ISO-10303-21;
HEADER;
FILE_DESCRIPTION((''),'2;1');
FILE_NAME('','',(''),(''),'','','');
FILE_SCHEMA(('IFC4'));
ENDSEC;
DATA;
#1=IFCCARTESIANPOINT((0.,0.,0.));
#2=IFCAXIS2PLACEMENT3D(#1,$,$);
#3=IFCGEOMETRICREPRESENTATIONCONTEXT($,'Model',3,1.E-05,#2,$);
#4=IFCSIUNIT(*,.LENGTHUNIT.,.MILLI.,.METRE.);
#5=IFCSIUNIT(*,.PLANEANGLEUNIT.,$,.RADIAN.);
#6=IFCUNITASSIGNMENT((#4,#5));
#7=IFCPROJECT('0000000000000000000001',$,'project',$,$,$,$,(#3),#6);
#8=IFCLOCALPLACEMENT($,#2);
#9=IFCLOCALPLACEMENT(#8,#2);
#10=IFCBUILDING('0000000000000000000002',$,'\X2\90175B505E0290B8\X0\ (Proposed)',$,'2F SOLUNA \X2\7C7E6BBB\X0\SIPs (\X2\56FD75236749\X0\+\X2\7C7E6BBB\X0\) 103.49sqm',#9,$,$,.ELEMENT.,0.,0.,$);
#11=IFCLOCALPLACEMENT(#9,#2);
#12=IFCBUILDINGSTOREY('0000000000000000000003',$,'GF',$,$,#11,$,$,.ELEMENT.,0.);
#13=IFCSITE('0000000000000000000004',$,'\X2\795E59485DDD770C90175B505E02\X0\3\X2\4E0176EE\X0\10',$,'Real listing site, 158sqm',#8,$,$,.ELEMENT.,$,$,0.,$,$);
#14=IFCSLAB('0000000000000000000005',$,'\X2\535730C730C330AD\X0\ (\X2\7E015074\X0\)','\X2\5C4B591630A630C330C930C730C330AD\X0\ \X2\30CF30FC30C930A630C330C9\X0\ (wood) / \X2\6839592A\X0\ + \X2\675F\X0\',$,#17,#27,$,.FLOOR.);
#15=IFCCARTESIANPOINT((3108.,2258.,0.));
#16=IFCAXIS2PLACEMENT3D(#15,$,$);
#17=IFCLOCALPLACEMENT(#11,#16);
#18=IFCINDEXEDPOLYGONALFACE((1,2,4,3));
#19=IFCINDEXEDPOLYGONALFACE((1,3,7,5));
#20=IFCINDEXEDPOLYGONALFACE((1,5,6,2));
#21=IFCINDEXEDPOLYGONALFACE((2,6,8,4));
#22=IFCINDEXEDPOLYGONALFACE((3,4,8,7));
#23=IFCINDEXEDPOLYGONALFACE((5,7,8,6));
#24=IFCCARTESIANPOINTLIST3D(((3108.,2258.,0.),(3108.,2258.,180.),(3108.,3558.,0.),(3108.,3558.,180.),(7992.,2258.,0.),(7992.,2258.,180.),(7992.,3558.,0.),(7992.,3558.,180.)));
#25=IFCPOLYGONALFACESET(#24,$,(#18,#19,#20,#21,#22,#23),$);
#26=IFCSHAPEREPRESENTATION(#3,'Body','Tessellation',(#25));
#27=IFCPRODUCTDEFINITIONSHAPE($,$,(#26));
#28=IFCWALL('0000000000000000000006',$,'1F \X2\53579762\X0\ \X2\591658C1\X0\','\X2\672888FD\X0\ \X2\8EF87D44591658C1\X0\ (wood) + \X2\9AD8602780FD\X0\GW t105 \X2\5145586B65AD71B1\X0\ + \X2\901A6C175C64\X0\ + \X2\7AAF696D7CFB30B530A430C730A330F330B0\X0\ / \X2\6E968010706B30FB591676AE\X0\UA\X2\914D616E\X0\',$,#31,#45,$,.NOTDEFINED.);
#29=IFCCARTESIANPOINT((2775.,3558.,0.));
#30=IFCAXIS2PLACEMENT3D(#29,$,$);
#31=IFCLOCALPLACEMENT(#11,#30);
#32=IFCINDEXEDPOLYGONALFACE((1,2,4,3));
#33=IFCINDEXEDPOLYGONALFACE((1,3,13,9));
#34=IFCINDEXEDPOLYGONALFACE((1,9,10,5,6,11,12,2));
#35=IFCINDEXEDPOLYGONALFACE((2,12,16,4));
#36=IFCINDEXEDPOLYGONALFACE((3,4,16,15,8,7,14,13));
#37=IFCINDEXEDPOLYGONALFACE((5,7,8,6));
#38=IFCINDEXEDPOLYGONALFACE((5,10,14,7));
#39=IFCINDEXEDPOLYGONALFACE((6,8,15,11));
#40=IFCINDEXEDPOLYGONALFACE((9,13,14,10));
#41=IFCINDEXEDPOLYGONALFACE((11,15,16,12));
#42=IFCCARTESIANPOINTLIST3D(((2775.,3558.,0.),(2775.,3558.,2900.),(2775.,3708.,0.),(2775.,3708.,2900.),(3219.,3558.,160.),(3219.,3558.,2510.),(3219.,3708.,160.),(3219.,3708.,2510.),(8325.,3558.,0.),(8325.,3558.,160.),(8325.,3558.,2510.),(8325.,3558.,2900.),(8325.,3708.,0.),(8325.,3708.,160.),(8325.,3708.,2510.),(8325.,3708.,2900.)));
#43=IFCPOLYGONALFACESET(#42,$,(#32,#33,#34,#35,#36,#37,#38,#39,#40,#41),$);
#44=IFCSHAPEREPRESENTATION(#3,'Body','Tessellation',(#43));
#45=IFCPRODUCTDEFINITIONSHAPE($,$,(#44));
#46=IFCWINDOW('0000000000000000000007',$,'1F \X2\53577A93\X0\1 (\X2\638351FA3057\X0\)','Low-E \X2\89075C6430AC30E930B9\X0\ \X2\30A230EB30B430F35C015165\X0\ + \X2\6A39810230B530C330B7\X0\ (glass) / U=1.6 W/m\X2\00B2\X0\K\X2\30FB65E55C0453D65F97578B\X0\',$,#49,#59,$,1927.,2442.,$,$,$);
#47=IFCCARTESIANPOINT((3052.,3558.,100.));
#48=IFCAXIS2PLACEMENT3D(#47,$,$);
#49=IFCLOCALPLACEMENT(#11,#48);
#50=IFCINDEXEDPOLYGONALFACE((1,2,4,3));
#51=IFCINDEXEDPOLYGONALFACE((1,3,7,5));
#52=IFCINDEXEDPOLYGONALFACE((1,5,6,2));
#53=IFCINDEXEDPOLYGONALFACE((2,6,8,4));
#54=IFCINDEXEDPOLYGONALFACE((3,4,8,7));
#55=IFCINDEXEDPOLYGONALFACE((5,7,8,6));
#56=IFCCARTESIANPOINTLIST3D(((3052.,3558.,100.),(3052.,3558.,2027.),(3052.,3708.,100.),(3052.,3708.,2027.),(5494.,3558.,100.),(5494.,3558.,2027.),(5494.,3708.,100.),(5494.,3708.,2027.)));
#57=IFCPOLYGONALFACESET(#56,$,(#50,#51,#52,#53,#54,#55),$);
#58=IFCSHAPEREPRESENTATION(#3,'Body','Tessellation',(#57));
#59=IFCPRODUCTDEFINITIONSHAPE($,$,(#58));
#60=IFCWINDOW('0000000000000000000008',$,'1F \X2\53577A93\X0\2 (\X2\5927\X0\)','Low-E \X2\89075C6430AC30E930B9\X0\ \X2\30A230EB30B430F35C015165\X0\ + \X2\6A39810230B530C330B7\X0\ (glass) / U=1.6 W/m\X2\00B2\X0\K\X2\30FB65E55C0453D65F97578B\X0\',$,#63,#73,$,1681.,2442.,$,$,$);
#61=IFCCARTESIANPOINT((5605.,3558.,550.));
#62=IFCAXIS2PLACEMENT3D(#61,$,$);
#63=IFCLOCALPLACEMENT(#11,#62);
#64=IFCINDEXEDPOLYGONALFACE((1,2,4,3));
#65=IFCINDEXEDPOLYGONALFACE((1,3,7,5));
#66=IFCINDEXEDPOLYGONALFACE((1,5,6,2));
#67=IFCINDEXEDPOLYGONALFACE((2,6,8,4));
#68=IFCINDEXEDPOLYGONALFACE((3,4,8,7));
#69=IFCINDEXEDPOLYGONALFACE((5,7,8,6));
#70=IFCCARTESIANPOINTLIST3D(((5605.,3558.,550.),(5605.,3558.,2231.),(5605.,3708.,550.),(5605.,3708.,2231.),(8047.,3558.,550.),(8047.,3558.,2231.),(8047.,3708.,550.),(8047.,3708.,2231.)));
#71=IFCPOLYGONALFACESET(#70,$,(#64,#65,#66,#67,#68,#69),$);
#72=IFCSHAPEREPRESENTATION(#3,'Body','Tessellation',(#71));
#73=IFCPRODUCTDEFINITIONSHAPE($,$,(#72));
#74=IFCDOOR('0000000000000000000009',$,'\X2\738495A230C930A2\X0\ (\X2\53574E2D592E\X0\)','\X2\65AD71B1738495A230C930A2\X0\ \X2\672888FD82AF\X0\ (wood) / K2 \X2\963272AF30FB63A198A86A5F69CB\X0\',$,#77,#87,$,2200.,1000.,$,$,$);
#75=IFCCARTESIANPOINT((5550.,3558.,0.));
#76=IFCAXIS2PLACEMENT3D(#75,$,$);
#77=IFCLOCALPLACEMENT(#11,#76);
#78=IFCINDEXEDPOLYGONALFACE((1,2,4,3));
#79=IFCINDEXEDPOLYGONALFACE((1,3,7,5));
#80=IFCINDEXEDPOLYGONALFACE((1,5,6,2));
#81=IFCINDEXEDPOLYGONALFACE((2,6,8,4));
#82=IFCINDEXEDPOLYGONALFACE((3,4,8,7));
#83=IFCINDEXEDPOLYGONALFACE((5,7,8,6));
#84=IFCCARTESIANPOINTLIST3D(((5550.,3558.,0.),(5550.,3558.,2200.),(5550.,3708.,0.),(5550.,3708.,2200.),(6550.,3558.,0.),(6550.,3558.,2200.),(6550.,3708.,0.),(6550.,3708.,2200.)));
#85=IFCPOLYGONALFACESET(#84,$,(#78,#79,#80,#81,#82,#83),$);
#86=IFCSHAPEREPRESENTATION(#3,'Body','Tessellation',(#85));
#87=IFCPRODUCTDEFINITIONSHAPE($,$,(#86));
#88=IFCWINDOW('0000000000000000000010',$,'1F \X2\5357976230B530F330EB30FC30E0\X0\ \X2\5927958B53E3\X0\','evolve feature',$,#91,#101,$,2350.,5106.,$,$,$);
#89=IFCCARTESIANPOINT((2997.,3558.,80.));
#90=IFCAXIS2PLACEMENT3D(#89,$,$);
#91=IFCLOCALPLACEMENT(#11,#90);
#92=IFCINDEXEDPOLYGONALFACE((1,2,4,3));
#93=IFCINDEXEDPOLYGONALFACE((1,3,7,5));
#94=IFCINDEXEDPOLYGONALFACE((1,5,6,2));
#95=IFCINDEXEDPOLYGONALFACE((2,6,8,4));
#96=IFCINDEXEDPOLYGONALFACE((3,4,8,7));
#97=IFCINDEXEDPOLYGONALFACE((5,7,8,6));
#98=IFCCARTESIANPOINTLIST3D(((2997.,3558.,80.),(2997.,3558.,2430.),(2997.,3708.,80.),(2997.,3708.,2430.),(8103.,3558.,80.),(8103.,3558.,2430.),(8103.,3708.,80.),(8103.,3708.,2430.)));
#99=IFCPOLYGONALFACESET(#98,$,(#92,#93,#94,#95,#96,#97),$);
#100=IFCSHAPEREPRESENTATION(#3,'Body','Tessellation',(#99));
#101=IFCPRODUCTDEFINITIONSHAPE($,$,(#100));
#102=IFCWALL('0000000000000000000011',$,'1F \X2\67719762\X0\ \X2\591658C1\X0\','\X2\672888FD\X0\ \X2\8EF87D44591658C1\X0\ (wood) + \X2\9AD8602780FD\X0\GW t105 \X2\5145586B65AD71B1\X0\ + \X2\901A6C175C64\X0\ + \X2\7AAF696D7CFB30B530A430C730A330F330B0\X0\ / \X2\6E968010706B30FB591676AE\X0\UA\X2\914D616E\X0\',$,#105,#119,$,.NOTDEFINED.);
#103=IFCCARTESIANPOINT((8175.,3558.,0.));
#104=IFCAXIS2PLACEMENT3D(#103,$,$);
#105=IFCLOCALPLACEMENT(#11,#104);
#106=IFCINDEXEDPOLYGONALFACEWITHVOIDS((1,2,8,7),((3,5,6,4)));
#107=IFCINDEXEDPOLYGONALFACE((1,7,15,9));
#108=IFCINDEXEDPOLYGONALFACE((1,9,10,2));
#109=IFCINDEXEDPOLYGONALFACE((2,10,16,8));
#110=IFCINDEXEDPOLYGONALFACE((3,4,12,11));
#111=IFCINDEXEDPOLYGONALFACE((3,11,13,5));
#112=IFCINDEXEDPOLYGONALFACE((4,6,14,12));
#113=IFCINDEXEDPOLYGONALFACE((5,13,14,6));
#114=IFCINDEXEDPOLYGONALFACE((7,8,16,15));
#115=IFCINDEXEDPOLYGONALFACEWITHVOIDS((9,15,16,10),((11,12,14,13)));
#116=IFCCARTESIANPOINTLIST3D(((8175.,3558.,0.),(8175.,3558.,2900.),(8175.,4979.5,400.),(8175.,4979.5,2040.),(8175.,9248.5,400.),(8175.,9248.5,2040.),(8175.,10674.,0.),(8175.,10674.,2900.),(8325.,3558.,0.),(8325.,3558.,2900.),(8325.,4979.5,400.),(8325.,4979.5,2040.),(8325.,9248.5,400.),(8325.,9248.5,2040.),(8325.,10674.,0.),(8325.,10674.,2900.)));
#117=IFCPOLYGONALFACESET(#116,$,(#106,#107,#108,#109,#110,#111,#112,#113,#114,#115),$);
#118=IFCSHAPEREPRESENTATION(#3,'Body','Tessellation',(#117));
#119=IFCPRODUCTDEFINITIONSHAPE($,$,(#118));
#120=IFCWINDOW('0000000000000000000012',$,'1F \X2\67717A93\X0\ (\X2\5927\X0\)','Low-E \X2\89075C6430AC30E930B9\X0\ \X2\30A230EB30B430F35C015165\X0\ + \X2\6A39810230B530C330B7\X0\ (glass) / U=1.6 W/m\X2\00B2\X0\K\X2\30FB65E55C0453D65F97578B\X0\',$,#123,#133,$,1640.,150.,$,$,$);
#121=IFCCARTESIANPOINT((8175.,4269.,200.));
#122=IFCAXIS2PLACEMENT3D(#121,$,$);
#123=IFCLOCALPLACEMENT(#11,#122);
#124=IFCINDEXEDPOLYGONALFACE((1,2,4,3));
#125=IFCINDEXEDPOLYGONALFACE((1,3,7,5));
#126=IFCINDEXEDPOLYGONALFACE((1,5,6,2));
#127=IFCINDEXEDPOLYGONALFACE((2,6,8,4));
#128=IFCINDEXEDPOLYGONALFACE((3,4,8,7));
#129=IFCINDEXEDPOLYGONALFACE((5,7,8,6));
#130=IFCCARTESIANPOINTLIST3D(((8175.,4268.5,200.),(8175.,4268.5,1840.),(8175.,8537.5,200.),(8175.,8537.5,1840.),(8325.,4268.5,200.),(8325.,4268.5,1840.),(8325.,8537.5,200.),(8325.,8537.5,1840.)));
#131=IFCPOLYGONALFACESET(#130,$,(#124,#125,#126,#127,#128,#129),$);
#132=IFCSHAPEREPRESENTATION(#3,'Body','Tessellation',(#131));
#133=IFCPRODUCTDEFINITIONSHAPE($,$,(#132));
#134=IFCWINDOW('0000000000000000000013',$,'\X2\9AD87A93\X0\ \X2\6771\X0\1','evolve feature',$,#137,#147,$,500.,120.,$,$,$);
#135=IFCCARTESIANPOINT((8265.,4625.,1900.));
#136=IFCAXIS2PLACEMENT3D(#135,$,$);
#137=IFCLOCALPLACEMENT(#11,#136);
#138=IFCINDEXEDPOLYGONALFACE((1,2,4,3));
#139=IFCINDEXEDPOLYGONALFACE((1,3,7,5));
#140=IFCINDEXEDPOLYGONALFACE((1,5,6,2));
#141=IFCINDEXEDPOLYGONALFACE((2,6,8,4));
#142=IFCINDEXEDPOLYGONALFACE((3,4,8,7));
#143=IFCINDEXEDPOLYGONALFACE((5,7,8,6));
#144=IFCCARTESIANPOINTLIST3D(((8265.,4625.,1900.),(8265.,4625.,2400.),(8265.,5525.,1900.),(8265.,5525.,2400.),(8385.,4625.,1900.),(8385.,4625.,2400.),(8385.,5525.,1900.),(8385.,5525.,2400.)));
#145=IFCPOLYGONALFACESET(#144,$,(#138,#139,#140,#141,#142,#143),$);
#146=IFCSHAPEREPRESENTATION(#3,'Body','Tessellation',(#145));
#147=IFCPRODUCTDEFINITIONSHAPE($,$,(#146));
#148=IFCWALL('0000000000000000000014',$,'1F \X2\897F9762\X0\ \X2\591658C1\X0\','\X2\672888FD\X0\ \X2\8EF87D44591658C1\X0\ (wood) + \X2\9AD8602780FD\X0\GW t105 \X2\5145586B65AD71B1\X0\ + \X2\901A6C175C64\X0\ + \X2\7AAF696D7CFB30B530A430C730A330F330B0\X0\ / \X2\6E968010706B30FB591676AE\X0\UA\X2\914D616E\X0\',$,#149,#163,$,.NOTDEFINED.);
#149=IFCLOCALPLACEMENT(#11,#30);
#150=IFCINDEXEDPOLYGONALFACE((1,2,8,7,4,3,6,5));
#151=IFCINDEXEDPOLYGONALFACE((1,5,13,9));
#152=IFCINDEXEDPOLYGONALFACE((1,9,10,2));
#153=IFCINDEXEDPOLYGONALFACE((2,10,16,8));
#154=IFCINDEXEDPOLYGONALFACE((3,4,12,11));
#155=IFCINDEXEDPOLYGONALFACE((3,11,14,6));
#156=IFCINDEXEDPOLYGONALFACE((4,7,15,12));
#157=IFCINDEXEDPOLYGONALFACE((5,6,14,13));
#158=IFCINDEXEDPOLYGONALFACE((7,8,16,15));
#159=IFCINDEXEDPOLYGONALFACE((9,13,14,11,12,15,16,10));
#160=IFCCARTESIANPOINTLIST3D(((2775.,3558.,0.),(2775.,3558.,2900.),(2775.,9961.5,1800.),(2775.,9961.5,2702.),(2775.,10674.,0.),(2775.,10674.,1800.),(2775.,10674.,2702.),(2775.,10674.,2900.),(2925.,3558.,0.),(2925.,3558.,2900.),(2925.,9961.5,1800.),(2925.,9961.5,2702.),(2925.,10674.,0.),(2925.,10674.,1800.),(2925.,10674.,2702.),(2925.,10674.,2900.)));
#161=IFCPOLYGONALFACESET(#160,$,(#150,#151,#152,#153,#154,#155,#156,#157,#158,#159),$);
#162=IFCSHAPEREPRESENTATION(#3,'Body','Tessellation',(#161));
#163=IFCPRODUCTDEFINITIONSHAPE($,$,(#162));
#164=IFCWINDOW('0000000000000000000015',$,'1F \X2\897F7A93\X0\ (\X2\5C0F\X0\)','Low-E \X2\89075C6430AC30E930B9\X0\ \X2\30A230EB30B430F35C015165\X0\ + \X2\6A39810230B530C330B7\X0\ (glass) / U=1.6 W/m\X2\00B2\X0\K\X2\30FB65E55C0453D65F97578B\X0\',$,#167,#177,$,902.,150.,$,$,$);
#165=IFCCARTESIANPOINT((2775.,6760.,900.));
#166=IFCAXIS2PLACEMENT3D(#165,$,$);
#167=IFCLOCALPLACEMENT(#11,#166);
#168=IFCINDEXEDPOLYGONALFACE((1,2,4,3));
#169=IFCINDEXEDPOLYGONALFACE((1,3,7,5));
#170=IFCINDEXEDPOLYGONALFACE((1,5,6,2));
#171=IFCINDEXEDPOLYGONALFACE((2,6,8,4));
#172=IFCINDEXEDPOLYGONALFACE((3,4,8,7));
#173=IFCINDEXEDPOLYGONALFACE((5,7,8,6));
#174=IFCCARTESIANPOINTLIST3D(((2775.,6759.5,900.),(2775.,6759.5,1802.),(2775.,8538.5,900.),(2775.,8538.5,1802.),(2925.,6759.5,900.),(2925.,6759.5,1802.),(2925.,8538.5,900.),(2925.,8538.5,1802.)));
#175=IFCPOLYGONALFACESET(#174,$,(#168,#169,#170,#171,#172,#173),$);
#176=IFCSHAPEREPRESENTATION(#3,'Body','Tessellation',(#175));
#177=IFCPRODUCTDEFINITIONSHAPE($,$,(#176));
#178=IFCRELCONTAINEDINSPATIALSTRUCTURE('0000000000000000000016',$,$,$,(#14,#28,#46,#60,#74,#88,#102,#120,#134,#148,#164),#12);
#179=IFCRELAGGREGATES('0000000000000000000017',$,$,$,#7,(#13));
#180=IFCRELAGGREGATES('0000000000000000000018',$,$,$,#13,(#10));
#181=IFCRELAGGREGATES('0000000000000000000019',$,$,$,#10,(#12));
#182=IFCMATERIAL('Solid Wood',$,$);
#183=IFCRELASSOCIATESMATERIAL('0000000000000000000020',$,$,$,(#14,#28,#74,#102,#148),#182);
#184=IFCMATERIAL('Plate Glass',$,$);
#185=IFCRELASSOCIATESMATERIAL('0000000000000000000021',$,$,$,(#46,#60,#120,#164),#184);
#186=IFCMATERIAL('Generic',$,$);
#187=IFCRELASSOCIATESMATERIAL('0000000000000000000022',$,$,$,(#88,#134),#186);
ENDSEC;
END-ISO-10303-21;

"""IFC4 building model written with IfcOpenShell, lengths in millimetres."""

from ifc_helpers import new_model, si_unit, frame, frame_2d, origin, place, context, project, spatial, rectangle, extrude, material, element, fill, save


model = new_model("IFC4")

# Units and contexts
model_context = context("Model", 3, precision=1e-05, world=origin())
ifc_project = project(units=[si_unit("LENGTHUNIT", "METRE", prefix="MILLI"), si_unit("PLANEANGLEUNIT", "RADIAN")], contexts=[model_context])

# Site, building, storey
site_placement = place(None, origin())
site = spatial("IfcSite", under=ifc_project, at=site_placement, Name="神奈川県逗子市3丁目10", ObjectType="Real listing site, 158sqm", CompositionType="ELEMENT", RefElevation=0.0)
building_placement = place(site_placement, origin())
building = spatial("IfcBuilding", under=site, at=building_placement, Name="逗子市邸 (Proposed)", ObjectType="2F SOLUNA 籾殻SIPs (国産杉+籾殻) 103.49sqm", CompositionType="ELEMENT", ElevationOfRefHeight=0.0, ElevationOfTerrain=0.0)
storey_placement = place(building_placement, origin())
storey = spatial("IfcBuildingStorey", under=building, at=storey_placement, Name="GF", CompositionType="ELEMENT", Elevation=0.0)

# Slab
ifc_material_1 = material(Name="Solid Wood")
slab_1_placement = place(storey_placement, frame((3108.0, 2258.0, 0.0)))
element("IfcSlab", 1, at=slab_1_placement, inside=storey, material=ifc_material_1, Name="南デッキ (縁側)", Description="屋外ウッドデッキ ハードウッド (wood) / 根太 + 束", PredefinedType="FLOOR", context=model_context, shape_type="SweptSolid", body=[
    extrude(rectangle(XDim=4884.0, YDim=1300.0, at=frame_2d((2442.0, 650.0))), frame((3108.0, 2258.0, 0.0)), (0.0, 0.0, 1.0), 180.0),
])
ifc_material_2 = material(Name="Generic")

# Wall, openings, windows, door
wall_1_placement = place(storey_placement, frame((2775.0, 3558.0, 0.0)))
wall_1 = element("IfcWall", 2, at=wall_1_placement, inside=storey, material=ifc_material_1, Name="1F 南面 外壁", Description="木製 軸組外壁 (wood) + 高性能GW t105 充填断熱 + 通気層 + 窯業系サイディング / 準耐火・外皮UA配慮", PredefinedType="NOTDEFINED", context=model_context, shape_type="SweptSolid", body=[
    extrude(rectangle(XDim=5550.0, YDim=150.0, at=frame_2d((2775.0, 75.0))), frame((2775.0, 3558.0, 0.0)), (0.0, 0.0, 1.0), 2900.0),
])
opening_1_placement = place(storey_placement, frame((3052.0, 3558.0, 100.0)))
opening_1 = element("IfcOpeningElement", 3, at=opening_1_placement, cuts=wall_1, PredefinedType="NOTDEFINED", context=model_context, shape_type="SweptSolid", body=[
    extrude(rectangle(XDim=2442.0, YDim=150.0, at=frame_2d((1221.0, 75.0))), frame((3052.0, 3558.0, 100.0)), (0.0, 0.0, 1.0), 1927.0),
])
opening_2_placement = place(storey_placement, frame((5605.0, 3558.0, 550.0)))
opening_2 = element("IfcOpeningElement", 4, at=opening_2_placement, cuts=wall_1, PredefinedType="NOTDEFINED", context=model_context, shape_type="SweptSolid", body=[
    extrude(rectangle(XDim=2442.0, YDim=150.0, at=frame_2d((1221.0, 75.0))), frame((5605.0, 3558.0, 550.0)), (0.0, 0.0, 1.0), 1681.0),
])
opening_3_placement = place(storey_placement, frame((5550.0, 3558.0, 0.0)))
opening_3 = element("IfcOpeningElement", 5, at=opening_3_placement, cuts=wall_1, PredefinedType="NOTDEFINED", context=model_context, shape_type="SweptSolid", body=[
    extrude(rectangle(XDim=1000.0, YDim=150.0, at=frame_2d((500.0, 75.0))), frame((5550.0, 3558.0, 0.0)), (0.0, 0.0, 1.0), 2200.0),
])
opening_4_placement = place(storey_placement, frame((2997.0, 3558.0, 80.0)))
opening_4 = element("IfcOpeningElement", 6, at=opening_4_placement, cuts=wall_1, PredefinedType="NOTDEFINED", context=model_context, shape_type="SweptSolid", body=[
    extrude(rectangle(XDim=5106.0, YDim=150.0, at=frame_2d((2553.0, 75.0))), frame((2997.0, 3558.0, 80.0)), (0.0, 0.0, 1.0), 2350.0),
])
ifc_material_3 = material(Name="Plate Glass")
window_1_placement = place(storey_placement, frame((3052.0, 3558.0, 100.0)))
window_1 = element("IfcWindow", 7, at=window_1_placement, inside=storey, material=ifc_material_3, Name="1F 南窓1 (掃出し)", Description="Low-E 複層ガラス アルゴン封入 + 樹脂サッシ (glass) / U=1.6 W/m²K・日射取得型", OverallHeight=1927.0, OverallWidth=2442.0, context=model_context, shape_type="SweptSolid", body=[
    extrude(rectangle(XDim=2442.0, YDim=150.0, at=frame_2d((1221.0, 75.0))), frame((3052.0, 3558.0, 100.0)), (0.0, 0.0, 1.0), 1927.0),
])
fill(opening_1, window_1)
window_2_placement = place(storey_placement, frame((5605.0, 3558.0, 550.0)))
window_2 = element("IfcWindow", 8, at=window_2_placement, inside=storey, material=ifc_material_3, Name="1F 南窓2 (大)", Description="Low-E 複層ガラス アルゴン封入 + 樹脂サッシ (glass) / U=1.6 W/m²K・日射取得型", OverallHeight=1681.0, OverallWidth=2442.0, context=model_context, shape_type="SweptSolid", body=[
    extrude(rectangle(XDim=2442.0, YDim=150.0, at=frame_2d((1221.0, 75.0))), frame((5605.0, 3558.0, 550.0)), (0.0, 0.0, 1.0), 1681.0),
])
fill(opening_2, window_2)
door_placement = place(storey_placement, frame((5550.0, 3558.0, 0.0)))
door = element("IfcDoor", 9, at=door_placement, inside=storey, material=ifc_material_1, Name="玄関ドア (南中央)", Description="断熱玄関ドア 木製芯 (wood) / K2 防犯・採風機構", OverallHeight=2200.0, OverallWidth=1000.0, context=model_context, shape_type="SweptSolid", body=[
    extrude(rectangle(XDim=1000.0, YDim=150.0, at=frame_2d((500.0, 75.0))), frame((5550.0, 3558.0, 0.0)), (0.0, 0.0, 1.0), 2200.0),
])
fill(opening_3, door)
window_3_placement = place(storey_placement, frame((2997.0, 3558.0, 80.0)))
window_3 = element("IfcWindow", 10, at=window_3_placement, inside=storey, material=ifc_material_2, Name="1F 南面サンルーム 大開口", Description="evolve feature", OverallHeight=2350.0, OverallWidth=5106.0, context=model_context, shape_type="SweptSolid", body=[
    extrude(rectangle(XDim=5106.0, YDim=150.0, at=frame_2d((2553.0, 75.0))), frame((2997.0, 3558.0, 80.0)), (0.0, 0.0, 1.0), 2350.0),
])
fill(opening_4, window_3)

# Wall, openings, windows
wall_2_placement = place(storey_placement, frame((8175.0, 3558.0, 0.0)))
wall_2 = element("IfcWall", 11, at=wall_2_placement, inside=storey, material=ifc_material_1, Name="1F 東面 外壁", Description="木製 軸組外壁 (wood) + 高性能GW t105 充填断熱 + 通気層 + 窯業系サイディング / 準耐火・外皮UA配慮", PredefinedType="NOTDEFINED", context=model_context, shape_type="SweptSolid", body=[
    extrude(rectangle(XDim=150.0, YDim=7116.0, at=frame_2d((75.0, 3558.0))), frame((8175.0, 3558.0, 0.0)), (0.0, 0.0, 1.0), 2900.0),
])
opening_5_placement = place(storey_placement, frame((8175.0, 4269.0, 200.0)))
opening_5 = element("IfcOpeningElement", 12, at=opening_5_placement, cuts=wall_2, PredefinedType="NOTDEFINED", context=model_context, shape_type="SweptSolid", body=[
    extrude(rectangle(XDim=150.0, YDim=4269.0, at=frame_2d((75.0, 2134.0))), frame((8175.0, 4269.0, 200.0)), (0.0, 0.0, 1.0), 1640.0),
])
opening_6_placement = place(storey_placement, frame((8265.0, 4625.0, 1900.0)))
opening_6 = element("IfcOpeningElement", 13, at=opening_6_placement, cuts=wall_2, PredefinedType="NOTDEFINED", context=model_context, shape_type="SweptSolid", body=[
    extrude(rectangle(XDim=120.0, YDim=900.0, at=frame_2d((60.0, 450.0))), frame((8265.0, 4625.0, 1900.0)), (0.0, 0.0, 1.0), 500.0),
])
window_4_placement = place(storey_placement, frame((8175.0, 4269.0, 200.0)))
window_4 = element("IfcWindow", 14, at=window_4_placement, inside=storey, material=ifc_material_3, Name="1F 東窓 (大)", Description="Low-E 複層ガラス アルゴン封入 + 樹脂サッシ (glass) / U=1.6 W/m²K・日射取得型", OverallHeight=1640.0, OverallWidth=150.0, context=model_context, shape_type="SweptSolid", body=[
    extrude(rectangle(XDim=150.0, YDim=4269.0, at=frame_2d((75.0, 2134.0))), frame((8175.0, 4269.0, 200.0)), (0.0, 0.0, 1.0), 1640.0),
])
fill(opening_5, window_4)
window_5_placement = place(storey_placement, frame((8265.0, 4625.0, 1900.0)))
window_5 = element("IfcWindow", 15, at=window_5_placement, inside=storey, material=ifc_material_2, Name="高窓 東1", Description="evolve feature", OverallHeight=500.0, OverallWidth=120.0, context=model_context, shape_type="SweptSolid", body=[
    extrude(rectangle(XDim=120.0, YDim=900.0, at=frame_2d((60.0, 450.0))), frame((8265.0, 4625.0, 1900.0)), (0.0, 0.0, 1.0), 500.0),
])
fill(opening_6, window_5)

# Wall, opening, window
wall_3_placement = place(storey_placement, frame((2775.0, 3558.0, 0.0)))
wall_3 = element("IfcWall", 16, at=wall_3_placement, inside=storey, material=ifc_material_1, Name="1F 西面 外壁", Description="木製 軸組外壁 (wood) + 高性能GW t105 充填断熱 + 通気層 + 窯業系サイディング / 準耐火・外皮UA配慮", PredefinedType="NOTDEFINED", context=model_context, shape_type="SweptSolid", body=[
    extrude(rectangle(XDim=150.0, YDim=7116.0, at=frame_2d((75.0, 3558.0))), frame((2775.0, 3558.0, 0.0)), (0.0, 0.0, 1.0), 2900.0),
])
opening_7_placement = place(storey_placement, frame((2775.0, 6760.0, 900.0)))
opening_7 = element("IfcOpeningElement", 17, at=opening_7_placement, cuts=wall_3, PredefinedType="NOTDEFINED", context=model_context, shape_type="SweptSolid", body=[
    extrude(rectangle(XDim=150.0, YDim=1779.0, at=frame_2d((75.0, 889.0))), frame((2775.0, 6760.0, 900.0)), (0.0, 0.0, 1.0), 902.0),
])
window_6_placement = place(storey_placement, frame((2775.0, 6760.0, 900.0)))
window_6 = element("IfcWindow", 18, at=window_6_placement, inside=storey, material=ifc_material_3, Name="1F 西窓 (小)", Description="Low-E 複層ガラス アルゴン封入 + 樹脂サッシ (glass) / U=1.6 W/m²K・日射取得型", OverallHeight=902.0, OverallWidth=150.0, context=model_context, shape_type="SweptSolid", body=[
    extrude(rectangle(XDim=150.0, YDim=1779.0, at=frame_2d((75.0, 889.0))), frame((2775.0, 6760.0, 900.0)), (0.0, 0.0, 1.0), 902.0),
])
fill(opening_7, window_6)

save(model, "model.ifc")
